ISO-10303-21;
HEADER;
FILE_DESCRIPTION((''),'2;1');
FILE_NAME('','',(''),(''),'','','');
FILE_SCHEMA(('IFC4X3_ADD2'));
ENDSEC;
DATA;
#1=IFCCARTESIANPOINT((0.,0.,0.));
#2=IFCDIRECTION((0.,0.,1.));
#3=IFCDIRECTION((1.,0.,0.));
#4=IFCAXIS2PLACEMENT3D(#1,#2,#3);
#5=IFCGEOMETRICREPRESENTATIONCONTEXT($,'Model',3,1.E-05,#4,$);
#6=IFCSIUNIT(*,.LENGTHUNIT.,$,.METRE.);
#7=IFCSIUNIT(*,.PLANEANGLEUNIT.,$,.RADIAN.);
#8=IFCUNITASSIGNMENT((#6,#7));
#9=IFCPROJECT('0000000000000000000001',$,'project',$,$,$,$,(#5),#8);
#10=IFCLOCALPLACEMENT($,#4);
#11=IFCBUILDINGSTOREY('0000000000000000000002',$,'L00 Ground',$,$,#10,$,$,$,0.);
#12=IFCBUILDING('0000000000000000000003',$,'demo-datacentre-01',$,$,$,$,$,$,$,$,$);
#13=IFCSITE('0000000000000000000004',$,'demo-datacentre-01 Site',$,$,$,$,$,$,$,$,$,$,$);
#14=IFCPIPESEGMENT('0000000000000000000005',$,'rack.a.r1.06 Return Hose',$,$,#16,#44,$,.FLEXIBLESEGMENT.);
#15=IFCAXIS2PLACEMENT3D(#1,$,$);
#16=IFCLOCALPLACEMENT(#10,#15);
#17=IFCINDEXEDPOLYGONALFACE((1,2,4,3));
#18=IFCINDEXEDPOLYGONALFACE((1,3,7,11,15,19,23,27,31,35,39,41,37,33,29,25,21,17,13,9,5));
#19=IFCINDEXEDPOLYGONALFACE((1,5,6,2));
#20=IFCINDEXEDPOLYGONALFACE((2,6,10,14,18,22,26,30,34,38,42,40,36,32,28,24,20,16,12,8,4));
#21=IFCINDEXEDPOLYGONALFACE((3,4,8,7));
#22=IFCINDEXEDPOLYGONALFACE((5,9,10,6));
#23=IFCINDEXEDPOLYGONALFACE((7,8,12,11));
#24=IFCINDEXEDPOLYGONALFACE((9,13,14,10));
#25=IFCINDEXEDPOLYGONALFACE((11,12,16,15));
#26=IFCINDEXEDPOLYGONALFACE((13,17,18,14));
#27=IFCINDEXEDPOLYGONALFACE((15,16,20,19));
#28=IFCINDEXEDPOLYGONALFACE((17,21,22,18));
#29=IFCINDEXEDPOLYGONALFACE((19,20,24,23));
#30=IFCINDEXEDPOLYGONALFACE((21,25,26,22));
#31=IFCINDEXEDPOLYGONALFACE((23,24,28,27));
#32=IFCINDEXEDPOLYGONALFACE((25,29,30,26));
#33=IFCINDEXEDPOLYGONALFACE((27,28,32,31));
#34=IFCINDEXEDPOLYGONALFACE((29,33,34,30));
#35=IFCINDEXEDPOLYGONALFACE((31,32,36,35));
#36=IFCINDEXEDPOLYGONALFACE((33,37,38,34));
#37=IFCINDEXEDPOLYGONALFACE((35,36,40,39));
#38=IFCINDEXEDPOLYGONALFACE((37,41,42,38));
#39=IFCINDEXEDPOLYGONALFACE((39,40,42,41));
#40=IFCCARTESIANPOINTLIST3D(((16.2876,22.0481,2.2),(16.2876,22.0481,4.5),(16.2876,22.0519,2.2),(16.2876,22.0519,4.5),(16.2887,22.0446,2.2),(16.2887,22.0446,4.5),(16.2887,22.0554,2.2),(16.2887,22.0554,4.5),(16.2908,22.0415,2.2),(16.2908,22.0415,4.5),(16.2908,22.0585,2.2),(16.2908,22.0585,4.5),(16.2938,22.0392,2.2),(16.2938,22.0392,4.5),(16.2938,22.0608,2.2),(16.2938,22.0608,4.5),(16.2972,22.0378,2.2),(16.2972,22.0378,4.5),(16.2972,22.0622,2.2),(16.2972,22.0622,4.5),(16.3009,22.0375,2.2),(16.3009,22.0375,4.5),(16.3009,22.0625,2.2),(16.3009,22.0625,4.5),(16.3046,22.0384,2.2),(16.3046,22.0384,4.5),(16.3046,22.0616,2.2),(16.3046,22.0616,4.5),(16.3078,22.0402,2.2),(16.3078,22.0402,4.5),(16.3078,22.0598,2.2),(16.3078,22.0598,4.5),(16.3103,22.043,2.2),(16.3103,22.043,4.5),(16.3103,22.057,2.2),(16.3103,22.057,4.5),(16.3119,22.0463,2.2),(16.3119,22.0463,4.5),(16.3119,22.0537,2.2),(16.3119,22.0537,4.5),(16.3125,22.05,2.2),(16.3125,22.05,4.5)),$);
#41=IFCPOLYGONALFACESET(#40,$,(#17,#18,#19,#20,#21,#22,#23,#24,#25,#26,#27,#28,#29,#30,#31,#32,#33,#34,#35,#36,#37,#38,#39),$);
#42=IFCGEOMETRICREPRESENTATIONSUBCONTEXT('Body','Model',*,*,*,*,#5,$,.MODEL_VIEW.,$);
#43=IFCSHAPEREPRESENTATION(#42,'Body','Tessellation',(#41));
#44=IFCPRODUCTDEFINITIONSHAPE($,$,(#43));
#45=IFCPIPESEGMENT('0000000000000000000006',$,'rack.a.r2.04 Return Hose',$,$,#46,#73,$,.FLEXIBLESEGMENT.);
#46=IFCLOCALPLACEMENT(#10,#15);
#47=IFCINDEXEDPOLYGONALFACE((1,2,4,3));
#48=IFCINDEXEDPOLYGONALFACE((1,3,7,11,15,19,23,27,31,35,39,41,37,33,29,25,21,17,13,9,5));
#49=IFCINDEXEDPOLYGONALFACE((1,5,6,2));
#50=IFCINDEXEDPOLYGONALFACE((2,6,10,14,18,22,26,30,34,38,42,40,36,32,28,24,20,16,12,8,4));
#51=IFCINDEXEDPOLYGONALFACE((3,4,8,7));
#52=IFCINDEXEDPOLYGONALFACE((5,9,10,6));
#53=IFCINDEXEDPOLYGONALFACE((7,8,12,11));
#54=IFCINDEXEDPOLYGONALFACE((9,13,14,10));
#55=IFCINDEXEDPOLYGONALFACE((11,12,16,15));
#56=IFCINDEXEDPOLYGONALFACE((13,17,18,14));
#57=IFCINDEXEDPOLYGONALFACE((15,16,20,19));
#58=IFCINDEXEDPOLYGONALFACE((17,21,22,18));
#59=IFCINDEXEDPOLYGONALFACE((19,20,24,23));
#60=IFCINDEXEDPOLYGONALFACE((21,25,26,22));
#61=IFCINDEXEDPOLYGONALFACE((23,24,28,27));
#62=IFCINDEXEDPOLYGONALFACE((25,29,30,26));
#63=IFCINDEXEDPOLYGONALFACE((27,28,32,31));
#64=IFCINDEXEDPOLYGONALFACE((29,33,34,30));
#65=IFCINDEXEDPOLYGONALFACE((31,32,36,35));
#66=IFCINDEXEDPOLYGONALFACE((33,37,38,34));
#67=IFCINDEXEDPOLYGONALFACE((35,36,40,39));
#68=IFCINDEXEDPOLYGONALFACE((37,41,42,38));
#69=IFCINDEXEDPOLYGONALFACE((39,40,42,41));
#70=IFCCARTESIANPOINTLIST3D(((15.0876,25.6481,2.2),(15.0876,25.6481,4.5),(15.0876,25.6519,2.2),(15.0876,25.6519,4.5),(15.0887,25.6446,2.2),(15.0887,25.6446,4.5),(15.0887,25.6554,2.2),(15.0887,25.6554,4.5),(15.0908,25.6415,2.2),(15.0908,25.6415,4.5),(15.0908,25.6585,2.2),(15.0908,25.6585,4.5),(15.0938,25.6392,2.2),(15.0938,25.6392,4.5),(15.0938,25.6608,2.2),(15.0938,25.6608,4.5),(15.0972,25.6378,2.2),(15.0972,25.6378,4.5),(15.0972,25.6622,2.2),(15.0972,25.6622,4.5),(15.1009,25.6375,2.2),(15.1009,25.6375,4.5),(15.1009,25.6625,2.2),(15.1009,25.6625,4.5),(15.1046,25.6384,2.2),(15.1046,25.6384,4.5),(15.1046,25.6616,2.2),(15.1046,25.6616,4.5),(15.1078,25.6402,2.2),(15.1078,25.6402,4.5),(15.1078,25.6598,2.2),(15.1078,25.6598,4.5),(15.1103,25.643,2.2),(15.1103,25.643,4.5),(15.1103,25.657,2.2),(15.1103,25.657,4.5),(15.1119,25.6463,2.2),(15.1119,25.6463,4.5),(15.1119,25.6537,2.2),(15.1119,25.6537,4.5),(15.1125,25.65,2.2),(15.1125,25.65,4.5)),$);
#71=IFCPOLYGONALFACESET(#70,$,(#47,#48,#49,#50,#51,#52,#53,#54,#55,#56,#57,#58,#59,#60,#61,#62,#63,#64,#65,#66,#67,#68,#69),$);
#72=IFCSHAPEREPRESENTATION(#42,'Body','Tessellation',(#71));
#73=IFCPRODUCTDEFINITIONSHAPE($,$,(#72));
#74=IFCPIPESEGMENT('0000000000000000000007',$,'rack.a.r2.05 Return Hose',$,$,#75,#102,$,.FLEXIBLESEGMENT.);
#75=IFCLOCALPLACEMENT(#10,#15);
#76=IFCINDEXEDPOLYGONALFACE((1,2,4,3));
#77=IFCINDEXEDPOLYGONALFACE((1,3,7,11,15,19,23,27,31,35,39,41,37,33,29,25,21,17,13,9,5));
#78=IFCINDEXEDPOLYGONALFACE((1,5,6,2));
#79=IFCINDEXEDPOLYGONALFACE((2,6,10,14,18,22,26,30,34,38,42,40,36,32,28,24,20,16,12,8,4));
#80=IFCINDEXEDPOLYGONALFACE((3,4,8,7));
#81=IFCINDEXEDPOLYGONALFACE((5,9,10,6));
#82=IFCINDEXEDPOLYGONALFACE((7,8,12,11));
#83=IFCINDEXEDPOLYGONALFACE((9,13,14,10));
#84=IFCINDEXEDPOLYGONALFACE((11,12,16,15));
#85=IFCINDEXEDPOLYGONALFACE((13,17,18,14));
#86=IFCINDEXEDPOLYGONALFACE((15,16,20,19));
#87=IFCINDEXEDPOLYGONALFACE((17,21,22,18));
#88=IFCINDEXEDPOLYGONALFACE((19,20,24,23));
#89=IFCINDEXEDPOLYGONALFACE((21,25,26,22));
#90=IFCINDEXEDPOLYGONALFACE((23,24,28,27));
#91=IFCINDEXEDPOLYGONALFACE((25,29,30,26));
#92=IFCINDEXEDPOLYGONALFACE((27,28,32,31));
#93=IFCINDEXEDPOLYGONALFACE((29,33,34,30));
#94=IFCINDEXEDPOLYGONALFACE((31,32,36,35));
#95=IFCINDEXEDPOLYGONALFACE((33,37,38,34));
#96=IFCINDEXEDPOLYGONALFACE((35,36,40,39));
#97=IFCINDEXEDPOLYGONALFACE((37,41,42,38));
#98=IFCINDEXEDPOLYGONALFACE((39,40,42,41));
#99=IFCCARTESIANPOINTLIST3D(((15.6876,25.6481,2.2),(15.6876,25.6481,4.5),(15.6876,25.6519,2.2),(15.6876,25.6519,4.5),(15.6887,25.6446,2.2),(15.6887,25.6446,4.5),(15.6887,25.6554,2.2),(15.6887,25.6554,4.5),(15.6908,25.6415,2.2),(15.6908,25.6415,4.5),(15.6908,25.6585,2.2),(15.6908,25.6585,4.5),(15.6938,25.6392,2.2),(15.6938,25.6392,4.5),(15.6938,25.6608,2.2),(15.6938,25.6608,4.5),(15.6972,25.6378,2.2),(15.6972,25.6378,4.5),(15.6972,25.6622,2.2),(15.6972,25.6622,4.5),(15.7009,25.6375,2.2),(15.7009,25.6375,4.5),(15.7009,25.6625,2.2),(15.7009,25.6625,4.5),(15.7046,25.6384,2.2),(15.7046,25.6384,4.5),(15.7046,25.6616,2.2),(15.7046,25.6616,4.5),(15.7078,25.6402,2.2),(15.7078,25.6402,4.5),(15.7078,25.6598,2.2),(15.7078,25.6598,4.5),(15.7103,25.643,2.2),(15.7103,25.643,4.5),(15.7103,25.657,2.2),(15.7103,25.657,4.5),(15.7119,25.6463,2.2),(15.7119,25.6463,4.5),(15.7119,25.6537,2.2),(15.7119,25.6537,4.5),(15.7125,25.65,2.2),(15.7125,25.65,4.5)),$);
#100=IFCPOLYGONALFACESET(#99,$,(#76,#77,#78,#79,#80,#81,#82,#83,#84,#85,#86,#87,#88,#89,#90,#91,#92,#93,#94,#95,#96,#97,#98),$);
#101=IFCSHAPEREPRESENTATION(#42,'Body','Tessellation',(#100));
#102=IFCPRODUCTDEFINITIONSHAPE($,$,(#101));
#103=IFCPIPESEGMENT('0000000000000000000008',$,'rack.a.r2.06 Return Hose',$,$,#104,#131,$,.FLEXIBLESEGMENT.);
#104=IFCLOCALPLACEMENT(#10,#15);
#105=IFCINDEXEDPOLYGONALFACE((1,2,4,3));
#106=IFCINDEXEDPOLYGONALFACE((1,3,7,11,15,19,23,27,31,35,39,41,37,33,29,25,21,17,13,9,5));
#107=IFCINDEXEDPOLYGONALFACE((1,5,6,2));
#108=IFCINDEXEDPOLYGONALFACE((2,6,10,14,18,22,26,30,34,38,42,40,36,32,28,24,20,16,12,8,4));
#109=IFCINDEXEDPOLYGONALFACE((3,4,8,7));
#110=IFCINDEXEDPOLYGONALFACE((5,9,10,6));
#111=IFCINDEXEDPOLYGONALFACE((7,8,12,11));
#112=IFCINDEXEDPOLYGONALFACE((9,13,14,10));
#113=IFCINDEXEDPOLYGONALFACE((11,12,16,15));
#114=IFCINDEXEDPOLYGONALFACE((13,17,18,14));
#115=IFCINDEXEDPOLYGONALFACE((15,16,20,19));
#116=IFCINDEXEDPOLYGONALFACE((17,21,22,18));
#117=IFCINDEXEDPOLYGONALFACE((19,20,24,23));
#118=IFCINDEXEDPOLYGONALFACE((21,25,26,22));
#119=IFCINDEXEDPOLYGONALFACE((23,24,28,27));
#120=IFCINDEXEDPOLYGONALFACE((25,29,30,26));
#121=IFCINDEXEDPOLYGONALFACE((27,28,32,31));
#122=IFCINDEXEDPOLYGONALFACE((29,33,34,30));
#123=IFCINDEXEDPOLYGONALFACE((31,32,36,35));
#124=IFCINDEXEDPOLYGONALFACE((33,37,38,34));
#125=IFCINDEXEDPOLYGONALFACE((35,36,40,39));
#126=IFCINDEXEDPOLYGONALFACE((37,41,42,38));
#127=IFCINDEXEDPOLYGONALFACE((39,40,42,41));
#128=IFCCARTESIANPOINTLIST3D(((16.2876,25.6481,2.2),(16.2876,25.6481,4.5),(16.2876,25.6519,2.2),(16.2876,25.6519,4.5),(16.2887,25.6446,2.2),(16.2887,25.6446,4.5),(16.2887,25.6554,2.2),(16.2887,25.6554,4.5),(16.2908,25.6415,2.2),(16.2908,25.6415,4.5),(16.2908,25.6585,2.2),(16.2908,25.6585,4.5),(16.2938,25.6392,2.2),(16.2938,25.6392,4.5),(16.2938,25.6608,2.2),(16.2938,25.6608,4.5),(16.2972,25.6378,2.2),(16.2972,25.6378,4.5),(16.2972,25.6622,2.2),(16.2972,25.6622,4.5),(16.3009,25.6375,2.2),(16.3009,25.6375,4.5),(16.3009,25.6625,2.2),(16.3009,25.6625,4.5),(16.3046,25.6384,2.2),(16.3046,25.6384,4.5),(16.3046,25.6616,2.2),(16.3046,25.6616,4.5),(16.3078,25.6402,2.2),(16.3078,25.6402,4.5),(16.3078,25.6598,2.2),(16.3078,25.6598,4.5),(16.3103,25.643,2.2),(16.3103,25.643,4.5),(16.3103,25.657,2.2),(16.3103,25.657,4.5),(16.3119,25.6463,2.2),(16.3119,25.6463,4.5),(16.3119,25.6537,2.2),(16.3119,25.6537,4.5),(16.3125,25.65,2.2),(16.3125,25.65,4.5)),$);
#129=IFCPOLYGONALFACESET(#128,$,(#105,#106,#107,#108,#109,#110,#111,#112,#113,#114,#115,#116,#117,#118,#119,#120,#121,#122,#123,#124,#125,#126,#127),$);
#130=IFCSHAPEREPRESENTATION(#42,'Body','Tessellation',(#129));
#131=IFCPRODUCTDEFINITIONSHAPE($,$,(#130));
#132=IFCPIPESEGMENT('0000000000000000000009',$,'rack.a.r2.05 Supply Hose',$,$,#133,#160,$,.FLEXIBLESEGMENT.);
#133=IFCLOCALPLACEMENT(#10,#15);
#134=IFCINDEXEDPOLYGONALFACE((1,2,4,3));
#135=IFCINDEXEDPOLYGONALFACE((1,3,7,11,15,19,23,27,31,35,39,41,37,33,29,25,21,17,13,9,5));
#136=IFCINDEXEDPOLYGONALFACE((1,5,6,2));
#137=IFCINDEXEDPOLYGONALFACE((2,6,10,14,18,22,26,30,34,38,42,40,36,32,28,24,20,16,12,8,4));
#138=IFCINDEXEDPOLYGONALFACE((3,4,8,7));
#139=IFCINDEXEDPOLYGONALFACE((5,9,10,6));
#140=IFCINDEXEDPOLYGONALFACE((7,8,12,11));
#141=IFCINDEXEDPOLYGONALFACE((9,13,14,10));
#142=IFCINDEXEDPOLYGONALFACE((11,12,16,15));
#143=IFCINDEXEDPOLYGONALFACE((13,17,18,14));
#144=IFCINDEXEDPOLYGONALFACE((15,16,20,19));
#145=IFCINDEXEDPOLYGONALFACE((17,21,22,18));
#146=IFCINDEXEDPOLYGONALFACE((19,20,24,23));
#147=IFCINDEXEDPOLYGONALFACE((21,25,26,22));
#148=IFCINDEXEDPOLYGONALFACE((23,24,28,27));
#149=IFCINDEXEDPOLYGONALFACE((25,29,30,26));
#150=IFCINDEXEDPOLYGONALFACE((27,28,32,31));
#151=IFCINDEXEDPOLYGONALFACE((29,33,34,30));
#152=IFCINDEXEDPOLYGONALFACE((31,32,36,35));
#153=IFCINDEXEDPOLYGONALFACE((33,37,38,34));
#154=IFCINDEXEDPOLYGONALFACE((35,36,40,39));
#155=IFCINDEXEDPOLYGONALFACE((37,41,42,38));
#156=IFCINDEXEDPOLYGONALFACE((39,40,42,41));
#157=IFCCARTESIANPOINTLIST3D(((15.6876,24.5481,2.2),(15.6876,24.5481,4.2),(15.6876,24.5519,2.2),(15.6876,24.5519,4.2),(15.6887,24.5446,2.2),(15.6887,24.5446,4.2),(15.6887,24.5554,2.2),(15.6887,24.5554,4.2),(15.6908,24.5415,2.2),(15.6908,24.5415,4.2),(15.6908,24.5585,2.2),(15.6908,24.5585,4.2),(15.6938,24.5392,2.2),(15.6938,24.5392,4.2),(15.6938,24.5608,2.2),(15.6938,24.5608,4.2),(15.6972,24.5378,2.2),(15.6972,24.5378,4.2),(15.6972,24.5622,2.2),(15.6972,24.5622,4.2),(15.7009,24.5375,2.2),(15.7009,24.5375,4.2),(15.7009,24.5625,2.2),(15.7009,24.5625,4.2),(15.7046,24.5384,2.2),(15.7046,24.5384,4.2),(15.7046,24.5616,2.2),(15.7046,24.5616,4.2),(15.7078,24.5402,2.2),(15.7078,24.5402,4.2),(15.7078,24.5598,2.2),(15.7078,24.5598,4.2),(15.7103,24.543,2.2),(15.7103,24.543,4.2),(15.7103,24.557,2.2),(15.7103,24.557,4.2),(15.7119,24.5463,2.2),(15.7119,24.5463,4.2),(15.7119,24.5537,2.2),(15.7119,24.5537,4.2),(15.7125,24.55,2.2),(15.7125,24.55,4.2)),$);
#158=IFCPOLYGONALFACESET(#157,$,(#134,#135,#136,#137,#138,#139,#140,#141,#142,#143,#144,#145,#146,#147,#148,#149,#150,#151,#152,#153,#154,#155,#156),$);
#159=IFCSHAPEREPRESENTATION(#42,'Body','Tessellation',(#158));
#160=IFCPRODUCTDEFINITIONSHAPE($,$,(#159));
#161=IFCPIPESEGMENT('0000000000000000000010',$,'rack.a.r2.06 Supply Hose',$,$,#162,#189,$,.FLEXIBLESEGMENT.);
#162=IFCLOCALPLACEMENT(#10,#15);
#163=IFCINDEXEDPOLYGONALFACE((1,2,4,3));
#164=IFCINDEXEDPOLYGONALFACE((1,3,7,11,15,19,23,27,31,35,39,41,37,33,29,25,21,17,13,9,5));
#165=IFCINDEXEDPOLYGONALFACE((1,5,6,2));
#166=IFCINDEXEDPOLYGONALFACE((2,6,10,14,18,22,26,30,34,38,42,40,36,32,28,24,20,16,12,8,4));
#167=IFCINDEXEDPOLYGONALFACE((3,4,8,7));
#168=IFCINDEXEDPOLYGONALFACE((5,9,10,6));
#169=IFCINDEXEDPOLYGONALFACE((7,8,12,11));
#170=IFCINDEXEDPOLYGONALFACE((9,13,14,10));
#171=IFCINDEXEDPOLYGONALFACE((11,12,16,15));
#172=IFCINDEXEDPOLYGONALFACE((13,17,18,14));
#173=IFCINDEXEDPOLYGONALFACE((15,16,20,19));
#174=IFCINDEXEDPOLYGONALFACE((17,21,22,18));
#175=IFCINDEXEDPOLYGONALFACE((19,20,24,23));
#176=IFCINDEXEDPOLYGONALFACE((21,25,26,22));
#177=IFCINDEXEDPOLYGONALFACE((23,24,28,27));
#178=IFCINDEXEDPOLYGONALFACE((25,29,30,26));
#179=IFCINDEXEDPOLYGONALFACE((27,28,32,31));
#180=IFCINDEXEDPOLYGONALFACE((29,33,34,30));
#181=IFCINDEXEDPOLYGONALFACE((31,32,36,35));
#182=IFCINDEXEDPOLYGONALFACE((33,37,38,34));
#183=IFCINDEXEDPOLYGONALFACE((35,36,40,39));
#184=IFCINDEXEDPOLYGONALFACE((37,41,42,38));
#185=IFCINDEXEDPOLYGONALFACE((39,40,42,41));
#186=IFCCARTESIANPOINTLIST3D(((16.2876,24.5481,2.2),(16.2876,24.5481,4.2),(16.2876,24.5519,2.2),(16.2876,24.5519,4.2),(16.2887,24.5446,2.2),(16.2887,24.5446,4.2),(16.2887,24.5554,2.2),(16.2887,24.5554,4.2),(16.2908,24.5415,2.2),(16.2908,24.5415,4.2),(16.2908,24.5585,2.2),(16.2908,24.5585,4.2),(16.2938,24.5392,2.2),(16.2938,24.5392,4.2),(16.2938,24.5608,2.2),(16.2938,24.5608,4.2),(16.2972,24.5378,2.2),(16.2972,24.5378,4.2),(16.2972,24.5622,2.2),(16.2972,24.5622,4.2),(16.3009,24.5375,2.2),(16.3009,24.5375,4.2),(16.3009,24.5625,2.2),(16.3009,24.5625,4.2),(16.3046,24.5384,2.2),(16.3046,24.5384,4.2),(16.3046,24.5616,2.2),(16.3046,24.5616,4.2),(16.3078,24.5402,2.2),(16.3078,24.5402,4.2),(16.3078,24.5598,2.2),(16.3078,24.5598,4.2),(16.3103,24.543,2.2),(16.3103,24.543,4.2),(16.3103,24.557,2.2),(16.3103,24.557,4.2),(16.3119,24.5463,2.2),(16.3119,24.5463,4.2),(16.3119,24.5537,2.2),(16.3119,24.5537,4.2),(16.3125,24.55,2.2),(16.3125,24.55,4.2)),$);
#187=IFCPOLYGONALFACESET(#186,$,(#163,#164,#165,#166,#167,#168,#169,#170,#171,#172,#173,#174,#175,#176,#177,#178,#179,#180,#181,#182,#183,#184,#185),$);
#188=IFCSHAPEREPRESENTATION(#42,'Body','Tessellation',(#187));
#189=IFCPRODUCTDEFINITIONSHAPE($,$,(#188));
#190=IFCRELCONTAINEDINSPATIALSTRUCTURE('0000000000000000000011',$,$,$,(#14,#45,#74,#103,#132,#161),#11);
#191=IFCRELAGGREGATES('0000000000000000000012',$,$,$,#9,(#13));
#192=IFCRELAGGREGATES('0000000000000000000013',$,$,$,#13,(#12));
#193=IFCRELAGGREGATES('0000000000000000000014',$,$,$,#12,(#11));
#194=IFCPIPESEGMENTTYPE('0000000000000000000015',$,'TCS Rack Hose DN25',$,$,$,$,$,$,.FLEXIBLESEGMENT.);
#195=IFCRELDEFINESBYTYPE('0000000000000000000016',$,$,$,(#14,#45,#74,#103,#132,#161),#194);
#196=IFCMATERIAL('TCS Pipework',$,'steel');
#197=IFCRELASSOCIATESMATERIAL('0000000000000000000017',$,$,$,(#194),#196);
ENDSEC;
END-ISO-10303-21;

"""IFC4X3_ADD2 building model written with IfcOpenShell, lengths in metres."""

from ifc_helpers import new_model, si_unit, frame, origin_with_axes, place, context, subcontext, project, spatial, circle, extrude, material, type_object, element, save


model = new_model("IFC4X3_ADD2")

# Units and contexts
model_context = context("Model", 3, precision=1e-05, world=origin_with_axes())
body_context = subcontext(model_context, "Body", "Model", "MODEL_VIEW")
ifc_project = project(units=[si_unit("LENGTHUNIT", "METRE"), si_unit("PLANEANGLEUNIT", "RADIAN")], contexts=[model_context])

# Site, building, storey
site = spatial("IfcSite", under=ifc_project, Name="demo-datacentre-01 Site")
building = spatial("IfcBuilding", under=site, Name="demo-datacentre-01")
storey_placement = place(None, origin_with_axes())
storey = spatial("IfcBuildingStorey", under=building, at=storey_placement, Name="L00 Ground", Elevation=0.0)

# Shared definitions
ifc_material = material(Name="TCS Pipework", Category="steel")

# Pipe segments
pipe_segment_type_1 = type_object("IfcPipeSegmentType", Name="TCS Rack Hose DN25", PredefinedType="FLEXIBLESEGMENT", material=ifc_material)
for number, where, z_axis, x_axis, name in (
    (1, (16.3, 22.05, 4.5), (0.0, 0.0, -1.0), (1.0, 0.0, 0.0), "rack.a.r1.06 Return Hose"),
    (2, (15.1, 25.65, 4.5), (0.0, 0.0, -1.0), (1.0, 0.0, 0.0), "rack.a.r2.04 Return Hose"),
    (3, (15.7, 25.65, 4.5), (0.0, 0.0, -1.0), (1.0, 0.0, 0.0), "rack.a.r2.05 Return Hose"),
    (4, (16.3, 25.65, 4.5), (0.0, 0.0, -1.0), (1.0, 0.0, 0.0), "rack.a.r2.06 Return Hose"),
):
    element("IfcPipeSegment", number, at=place(storey_placement, frame(where, z_axis=z_axis, x_axis=x_axis)), inside=storey, type_object=pipe_segment_type_1, Name=name, PredefinedType="FLEXIBLESEGMENT", context=body_context, shape_type="SweptSolid", body=[
        extrude(circle(Radius=0.0125), origin_with_axes(), (0.0, 0.0, 1.0), 2.3),
    ])
for number, where, z_axis, x_axis, name in (
    (5, (15.7, 24.55, 4.2), (0.0, 0.0, -1.0), (1.0, 0.0, 0.0), "rack.a.r2.05 Supply Hose"),
    (6, (16.3, 24.55, 4.2), (0.0, 0.0, -1.0), (1.0, 0.0, 0.0), "rack.a.r2.06 Supply Hose"),
):
    element("IfcPipeSegment", number, at=place(storey_placement, frame(where, z_axis=z_axis, x_axis=x_axis)), inside=storey, type_object=pipe_segment_type_1, Name=name, PredefinedType="FLEXIBLESEGMENT", context=body_context, shape_type="SweptSolid", body=[
        extrude(circle(Radius=0.0125), origin_with_axes(), (0.0, 0.0, 1.0), 2.0),
    ])

save(model, "model.ifc")
